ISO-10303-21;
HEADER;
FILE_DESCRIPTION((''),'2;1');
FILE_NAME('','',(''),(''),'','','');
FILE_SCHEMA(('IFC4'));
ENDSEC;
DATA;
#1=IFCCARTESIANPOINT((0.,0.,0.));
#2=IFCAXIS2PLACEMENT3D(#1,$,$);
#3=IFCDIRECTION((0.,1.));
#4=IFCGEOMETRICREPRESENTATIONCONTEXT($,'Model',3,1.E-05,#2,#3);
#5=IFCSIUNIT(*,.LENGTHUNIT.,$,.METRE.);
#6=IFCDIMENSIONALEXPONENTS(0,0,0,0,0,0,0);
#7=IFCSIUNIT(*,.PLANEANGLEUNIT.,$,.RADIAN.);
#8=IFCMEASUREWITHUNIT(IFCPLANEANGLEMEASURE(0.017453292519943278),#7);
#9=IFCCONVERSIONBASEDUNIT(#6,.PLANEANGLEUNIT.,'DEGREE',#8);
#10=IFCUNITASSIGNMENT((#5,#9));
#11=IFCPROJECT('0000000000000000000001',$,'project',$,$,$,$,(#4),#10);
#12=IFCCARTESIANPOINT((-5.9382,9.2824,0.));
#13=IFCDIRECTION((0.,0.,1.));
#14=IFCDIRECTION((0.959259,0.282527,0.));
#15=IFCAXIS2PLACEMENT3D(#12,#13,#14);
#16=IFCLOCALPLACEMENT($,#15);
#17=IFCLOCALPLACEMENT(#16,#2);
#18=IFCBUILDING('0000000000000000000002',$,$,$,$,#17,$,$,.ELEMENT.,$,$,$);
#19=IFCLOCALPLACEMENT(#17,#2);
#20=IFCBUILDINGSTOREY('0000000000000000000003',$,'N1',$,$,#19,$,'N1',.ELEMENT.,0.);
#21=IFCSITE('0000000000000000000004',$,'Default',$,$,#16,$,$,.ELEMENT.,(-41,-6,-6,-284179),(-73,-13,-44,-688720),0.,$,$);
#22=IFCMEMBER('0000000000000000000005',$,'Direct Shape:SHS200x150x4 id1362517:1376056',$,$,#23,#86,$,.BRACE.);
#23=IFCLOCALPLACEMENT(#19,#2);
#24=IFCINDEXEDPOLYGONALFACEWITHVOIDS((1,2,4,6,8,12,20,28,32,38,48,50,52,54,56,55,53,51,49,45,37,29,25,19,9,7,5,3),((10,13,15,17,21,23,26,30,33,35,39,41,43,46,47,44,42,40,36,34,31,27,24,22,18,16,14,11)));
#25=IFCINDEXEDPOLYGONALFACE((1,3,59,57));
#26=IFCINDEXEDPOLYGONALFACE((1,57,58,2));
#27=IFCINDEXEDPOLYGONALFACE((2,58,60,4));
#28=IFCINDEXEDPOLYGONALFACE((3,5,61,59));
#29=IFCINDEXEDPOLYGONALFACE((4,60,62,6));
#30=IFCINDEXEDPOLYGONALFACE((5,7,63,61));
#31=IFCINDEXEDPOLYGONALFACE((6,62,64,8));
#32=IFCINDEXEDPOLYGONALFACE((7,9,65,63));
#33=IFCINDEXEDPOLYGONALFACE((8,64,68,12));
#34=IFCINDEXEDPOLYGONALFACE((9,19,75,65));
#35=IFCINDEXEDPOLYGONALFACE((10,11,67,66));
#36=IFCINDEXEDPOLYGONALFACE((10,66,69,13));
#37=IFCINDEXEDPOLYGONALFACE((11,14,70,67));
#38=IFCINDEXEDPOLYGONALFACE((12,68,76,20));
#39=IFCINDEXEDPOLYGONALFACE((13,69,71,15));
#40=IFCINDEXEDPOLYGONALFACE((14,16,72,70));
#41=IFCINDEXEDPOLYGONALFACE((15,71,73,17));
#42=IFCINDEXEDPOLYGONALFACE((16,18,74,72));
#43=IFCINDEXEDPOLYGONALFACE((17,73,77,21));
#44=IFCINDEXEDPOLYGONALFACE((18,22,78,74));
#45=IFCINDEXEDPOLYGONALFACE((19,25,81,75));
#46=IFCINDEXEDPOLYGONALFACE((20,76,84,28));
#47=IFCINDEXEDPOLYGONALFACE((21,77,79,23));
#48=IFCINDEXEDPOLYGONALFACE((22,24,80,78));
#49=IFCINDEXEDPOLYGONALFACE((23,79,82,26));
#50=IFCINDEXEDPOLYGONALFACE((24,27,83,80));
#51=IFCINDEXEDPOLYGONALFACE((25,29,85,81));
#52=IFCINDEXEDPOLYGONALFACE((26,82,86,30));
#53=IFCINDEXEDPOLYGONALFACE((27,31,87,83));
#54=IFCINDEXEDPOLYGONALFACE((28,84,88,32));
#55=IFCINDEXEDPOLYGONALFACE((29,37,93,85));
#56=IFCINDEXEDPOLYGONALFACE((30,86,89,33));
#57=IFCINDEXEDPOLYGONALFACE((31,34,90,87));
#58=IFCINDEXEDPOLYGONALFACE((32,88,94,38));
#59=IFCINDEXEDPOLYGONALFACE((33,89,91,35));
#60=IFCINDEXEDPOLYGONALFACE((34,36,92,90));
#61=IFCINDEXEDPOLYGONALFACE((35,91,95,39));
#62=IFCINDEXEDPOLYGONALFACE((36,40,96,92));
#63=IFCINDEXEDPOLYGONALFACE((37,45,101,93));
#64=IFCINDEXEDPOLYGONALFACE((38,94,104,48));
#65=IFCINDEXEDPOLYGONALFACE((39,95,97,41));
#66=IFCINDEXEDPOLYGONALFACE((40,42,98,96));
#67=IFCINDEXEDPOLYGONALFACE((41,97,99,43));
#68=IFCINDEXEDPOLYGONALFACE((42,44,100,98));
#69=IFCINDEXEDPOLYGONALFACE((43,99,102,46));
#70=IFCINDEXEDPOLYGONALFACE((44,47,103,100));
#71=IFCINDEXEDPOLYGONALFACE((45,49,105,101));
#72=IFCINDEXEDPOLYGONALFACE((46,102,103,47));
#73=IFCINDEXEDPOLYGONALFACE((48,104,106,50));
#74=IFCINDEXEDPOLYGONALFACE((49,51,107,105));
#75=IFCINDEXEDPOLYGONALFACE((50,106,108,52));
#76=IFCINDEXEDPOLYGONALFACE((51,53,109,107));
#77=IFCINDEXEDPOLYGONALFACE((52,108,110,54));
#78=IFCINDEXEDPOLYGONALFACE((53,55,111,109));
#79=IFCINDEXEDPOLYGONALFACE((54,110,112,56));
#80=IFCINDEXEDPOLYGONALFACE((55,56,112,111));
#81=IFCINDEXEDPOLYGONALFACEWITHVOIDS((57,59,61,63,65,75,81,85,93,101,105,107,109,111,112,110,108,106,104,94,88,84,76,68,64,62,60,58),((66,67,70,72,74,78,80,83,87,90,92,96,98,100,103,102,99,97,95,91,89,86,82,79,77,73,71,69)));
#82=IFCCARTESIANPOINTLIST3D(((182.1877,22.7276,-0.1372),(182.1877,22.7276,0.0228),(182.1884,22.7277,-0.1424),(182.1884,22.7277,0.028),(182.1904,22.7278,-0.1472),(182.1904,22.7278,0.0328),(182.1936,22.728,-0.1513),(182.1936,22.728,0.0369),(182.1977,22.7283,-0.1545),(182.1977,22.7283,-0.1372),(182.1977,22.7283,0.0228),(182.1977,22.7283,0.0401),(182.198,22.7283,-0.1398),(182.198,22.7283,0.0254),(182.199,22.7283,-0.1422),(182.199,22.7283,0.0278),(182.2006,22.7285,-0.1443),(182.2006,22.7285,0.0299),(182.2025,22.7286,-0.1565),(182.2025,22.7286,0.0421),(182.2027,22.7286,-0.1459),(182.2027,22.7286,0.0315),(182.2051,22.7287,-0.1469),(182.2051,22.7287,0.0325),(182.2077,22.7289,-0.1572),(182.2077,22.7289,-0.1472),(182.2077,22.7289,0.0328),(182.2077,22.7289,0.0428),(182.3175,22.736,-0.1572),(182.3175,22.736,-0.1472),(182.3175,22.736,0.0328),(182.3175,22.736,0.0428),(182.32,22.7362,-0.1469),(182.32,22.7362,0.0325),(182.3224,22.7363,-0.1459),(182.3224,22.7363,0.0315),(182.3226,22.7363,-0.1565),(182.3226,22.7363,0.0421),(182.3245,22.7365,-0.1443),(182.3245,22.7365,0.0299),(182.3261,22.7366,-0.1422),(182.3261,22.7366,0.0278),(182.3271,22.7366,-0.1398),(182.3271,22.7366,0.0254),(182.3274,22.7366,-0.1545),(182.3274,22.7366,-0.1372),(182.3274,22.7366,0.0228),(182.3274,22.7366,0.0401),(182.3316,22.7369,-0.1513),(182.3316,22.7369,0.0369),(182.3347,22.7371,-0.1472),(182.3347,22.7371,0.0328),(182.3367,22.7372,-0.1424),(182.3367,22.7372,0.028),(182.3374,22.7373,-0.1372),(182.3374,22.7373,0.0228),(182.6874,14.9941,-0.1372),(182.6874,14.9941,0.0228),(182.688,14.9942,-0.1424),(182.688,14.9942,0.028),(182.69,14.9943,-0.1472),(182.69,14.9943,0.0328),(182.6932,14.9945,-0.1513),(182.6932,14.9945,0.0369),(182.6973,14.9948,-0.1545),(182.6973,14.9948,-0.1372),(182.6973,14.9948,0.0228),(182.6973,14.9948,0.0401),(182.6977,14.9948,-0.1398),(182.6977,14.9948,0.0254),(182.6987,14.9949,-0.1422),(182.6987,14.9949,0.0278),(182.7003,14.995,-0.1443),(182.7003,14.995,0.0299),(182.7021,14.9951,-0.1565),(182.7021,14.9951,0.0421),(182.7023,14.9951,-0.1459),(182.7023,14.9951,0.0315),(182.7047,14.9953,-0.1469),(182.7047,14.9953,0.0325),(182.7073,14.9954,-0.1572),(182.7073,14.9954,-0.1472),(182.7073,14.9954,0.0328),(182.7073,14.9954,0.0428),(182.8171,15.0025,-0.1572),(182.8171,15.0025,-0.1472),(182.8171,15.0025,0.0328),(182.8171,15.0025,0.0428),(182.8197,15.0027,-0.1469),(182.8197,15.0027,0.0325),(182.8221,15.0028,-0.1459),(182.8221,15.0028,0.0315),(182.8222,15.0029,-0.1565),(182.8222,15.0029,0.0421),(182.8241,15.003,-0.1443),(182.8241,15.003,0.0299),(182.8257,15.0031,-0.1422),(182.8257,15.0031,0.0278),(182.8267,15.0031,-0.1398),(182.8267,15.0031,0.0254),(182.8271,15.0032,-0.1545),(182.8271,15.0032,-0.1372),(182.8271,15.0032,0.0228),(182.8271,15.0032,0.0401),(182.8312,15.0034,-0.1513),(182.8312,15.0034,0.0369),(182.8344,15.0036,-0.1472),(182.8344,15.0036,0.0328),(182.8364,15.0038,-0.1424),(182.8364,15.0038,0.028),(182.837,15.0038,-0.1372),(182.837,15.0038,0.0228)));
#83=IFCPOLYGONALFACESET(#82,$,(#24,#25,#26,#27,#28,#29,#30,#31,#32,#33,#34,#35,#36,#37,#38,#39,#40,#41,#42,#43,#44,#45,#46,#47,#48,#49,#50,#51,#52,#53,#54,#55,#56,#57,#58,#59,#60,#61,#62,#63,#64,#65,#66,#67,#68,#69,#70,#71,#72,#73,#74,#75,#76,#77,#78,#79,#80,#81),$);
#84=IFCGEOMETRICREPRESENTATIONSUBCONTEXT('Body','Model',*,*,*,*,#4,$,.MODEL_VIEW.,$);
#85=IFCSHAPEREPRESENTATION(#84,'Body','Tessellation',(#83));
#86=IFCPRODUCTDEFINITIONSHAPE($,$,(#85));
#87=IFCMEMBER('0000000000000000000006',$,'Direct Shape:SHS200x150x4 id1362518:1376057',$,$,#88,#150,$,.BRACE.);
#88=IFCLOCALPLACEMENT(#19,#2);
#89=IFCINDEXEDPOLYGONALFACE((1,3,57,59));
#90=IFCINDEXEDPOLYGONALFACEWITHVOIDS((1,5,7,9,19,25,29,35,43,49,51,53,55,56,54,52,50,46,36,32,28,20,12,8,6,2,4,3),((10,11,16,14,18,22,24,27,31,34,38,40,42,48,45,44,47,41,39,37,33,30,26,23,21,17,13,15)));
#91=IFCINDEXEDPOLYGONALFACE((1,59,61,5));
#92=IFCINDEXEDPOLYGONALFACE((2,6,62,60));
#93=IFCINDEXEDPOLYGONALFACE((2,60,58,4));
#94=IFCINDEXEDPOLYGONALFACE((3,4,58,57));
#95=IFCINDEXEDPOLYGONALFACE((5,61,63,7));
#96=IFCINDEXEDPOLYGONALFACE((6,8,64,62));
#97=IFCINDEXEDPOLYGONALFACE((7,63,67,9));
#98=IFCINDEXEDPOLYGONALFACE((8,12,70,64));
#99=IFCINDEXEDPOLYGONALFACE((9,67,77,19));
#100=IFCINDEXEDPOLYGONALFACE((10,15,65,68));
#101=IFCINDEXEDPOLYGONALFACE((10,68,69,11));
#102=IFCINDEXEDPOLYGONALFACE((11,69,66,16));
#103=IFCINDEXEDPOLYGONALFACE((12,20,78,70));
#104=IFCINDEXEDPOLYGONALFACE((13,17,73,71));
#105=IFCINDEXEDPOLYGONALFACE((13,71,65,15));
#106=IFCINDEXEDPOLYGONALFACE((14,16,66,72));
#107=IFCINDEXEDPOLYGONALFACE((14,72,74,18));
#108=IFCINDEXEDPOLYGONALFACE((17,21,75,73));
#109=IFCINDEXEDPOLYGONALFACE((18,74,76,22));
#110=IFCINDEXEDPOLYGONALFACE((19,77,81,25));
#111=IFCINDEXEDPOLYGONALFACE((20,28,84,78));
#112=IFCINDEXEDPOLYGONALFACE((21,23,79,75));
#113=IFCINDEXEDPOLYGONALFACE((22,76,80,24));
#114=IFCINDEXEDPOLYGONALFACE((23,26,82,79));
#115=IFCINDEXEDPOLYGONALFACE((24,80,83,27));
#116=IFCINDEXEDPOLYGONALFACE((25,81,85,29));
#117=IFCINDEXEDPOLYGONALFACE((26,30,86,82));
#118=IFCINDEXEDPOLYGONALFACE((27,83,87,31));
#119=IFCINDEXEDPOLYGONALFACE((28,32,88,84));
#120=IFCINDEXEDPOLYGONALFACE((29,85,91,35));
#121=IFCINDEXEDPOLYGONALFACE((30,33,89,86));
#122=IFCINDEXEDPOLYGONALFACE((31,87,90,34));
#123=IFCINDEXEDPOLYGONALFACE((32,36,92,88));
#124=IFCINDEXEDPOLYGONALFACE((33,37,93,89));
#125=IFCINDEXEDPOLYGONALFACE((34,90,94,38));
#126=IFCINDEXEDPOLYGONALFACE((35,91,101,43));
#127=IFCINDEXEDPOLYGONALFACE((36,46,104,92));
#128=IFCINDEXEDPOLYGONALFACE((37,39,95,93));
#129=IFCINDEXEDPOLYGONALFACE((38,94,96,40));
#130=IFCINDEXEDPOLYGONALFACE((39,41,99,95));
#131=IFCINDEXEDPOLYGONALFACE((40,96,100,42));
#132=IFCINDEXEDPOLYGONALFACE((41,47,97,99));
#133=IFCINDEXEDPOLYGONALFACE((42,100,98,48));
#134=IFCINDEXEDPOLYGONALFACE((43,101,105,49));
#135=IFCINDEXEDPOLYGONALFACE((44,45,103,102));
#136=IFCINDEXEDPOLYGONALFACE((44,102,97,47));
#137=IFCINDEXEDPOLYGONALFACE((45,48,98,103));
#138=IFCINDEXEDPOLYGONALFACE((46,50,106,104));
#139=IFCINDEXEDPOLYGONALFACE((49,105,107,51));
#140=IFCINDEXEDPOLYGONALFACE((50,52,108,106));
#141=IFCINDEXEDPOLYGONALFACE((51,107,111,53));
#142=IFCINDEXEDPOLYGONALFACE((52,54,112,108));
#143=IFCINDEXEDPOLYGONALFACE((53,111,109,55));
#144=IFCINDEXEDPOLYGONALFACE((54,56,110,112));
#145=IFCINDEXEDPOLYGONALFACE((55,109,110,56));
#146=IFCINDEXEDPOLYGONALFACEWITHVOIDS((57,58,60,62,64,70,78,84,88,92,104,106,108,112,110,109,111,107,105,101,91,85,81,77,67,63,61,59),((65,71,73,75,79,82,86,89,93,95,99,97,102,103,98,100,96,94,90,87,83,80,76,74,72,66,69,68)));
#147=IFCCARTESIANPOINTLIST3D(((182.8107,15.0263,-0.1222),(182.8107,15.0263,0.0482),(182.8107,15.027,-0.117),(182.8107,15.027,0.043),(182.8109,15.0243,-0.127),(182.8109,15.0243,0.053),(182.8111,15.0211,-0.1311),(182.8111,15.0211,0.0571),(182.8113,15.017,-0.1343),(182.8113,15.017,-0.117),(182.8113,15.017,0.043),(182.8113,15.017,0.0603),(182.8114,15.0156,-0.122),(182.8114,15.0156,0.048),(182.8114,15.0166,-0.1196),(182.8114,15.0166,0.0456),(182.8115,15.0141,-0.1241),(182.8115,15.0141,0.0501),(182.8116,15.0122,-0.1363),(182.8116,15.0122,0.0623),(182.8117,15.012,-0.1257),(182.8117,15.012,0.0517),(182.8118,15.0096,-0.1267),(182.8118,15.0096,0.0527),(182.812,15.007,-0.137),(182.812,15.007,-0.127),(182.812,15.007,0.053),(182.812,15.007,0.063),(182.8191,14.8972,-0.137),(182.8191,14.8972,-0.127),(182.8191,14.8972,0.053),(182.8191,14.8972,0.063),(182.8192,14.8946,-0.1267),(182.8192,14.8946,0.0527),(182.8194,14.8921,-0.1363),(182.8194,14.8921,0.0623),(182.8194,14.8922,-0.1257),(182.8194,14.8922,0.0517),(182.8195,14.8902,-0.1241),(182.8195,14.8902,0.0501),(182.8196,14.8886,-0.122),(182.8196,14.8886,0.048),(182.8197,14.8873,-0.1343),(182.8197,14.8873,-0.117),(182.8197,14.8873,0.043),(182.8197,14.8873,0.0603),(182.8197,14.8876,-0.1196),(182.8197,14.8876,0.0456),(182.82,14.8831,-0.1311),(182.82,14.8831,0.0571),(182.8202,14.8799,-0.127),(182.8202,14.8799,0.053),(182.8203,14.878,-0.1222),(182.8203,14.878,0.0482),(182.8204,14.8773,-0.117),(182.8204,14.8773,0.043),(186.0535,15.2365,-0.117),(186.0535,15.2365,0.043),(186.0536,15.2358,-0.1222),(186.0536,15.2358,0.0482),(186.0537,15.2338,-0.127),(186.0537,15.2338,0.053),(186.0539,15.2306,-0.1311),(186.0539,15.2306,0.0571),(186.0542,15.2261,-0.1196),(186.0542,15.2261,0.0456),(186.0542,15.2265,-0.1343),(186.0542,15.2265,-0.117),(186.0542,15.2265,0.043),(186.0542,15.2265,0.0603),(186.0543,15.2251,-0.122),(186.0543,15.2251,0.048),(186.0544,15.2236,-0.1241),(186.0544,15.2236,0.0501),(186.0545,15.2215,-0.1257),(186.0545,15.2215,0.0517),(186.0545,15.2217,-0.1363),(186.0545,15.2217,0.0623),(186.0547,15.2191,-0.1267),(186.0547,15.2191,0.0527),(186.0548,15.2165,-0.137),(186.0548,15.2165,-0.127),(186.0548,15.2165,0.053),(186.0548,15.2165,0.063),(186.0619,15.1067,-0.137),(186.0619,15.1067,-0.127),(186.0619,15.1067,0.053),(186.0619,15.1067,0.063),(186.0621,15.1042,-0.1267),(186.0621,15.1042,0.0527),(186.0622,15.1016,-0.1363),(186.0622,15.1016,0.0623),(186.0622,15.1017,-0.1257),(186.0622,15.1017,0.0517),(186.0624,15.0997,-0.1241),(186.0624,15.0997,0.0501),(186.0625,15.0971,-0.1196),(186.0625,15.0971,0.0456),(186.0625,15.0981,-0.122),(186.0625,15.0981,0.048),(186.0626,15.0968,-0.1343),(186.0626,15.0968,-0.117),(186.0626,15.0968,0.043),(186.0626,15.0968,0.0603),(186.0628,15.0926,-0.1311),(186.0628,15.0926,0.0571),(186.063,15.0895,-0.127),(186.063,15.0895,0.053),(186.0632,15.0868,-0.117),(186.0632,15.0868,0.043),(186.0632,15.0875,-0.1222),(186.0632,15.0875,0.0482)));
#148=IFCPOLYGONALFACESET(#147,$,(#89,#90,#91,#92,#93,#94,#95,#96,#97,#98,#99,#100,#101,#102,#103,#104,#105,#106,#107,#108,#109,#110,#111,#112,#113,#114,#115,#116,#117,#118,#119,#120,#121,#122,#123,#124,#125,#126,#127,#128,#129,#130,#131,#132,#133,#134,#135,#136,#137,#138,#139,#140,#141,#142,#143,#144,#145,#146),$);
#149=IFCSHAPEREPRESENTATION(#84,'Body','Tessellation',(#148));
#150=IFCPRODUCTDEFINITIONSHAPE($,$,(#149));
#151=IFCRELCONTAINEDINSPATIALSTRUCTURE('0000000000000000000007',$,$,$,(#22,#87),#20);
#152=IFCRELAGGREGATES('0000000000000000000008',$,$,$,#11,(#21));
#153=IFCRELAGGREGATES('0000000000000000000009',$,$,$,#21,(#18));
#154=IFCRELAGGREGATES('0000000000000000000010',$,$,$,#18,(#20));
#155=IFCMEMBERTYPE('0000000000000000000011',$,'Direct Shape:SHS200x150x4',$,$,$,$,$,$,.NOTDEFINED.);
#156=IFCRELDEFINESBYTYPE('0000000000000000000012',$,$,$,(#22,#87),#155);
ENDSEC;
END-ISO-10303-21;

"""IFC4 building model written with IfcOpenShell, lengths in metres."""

from ifc_helpers import new_model, entity, si_unit, converted_unit, direction, frame, frame_2d, origin, place, context, subcontext, project, spatial, polyline, circle_curve, parameter, trimmed, segment, composite_curve, outline, extrude, type_object, element, save


model = new_model("IFC4")

# Units and contexts
model_context = context("Model", 3, precision=1e-05, world=origin(), true_north=direction((0.0, 1.0)))
body_context = subcontext(model_context, "Body", "Model", "MODEL_VIEW")
ifc_project = project(units=[si_unit("LENGTHUNIT", "METRE"), converted_unit("PLANEANGLEUNIT", "DEGREE", entity("IfcPlaneAngleMeasure", 0.017453292519943278), si_unit("PLANEANGLEUNIT", "RADIAN"), dimensions=[0, 0, 0, 0, 0, 0, 0])], contexts=[model_context])

# Site, building, storey
site_placement = place(None, frame((-5.9382, 9.2824, 0.0), z_axis=(0.0, 0.0, 1.0), x_axis=(0.959259, 0.282527, 0.0)))
site = spatial("IfcSite", under=ifc_project, at=site_placement, Name="Default", CompositionType="ELEMENT", RefLatitude=(-41, -6, -6, -284179), RefLongitude=(-73, -13, -44, -688720), RefElevation=0.0)
building_placement = place(site_placement, origin())
building = spatial("IfcBuilding", under=site, at=building_placement, CompositionType="ELEMENT")
storey_placement = place(building_placement, origin())
storey = spatial("IfcBuildingStorey", under=building, at=storey_placement, Name="N1", LongName="N1", CompositionType="ELEMENT", Elevation=0.0)

# Members
member_type_1 = type_object("IfcMemberType", Name="Direct Shape:SHS200x150x4", PredefinedType="NOTDEFINED")
member_1_placement = place(storey_placement, origin())
element("IfcMember", 1, at=member_1_placement, inside=storey, type_object=member_type_1, Name="Direct Shape:SHS200x150x4 id1362517:1376056", PredefinedType="BRACE", context=body_context, shape_type="SweptSolid", body=[
    extrude(outline(composite_curve([segment(polyline([(-0.08, -0.075), (0.08, -0.075)]), True, "CONTINUOUS"), segment(trimmed(circle_curve(frame_2d((0.08, -0.055), x_axis=(0.0, 1.0)), 0.02), [parameter(180.0)], [parameter(270.0)], True, "PARAMETER"), True, "CONTINUOUS"), segment(polyline([(0.1, -0.055), (0.1, 0.055)]), True, "CONTINUOUS"), segment(trimmed(circle_curve(frame_2d((0.08, 0.055), x_axis=(0.0, 1.0)), 0.02), [parameter(270.0)], [parameter(0.0)], True, "PARAMETER"), True, "CONTINUOUS"), segment(polyline([(0.08, 0.075), (-0.08, 0.075)]), True, "CONTINUOUS"), segment(trimmed(circle_curve(frame_2d((-0.08, 0.055), x_axis=(0.0, 1.0)), 0.02), [parameter(360.0)], [parameter(90.0)], True, "PARAMETER"), True, "CONTINUOUS"), segment(polyline([(-0.1, 0.055), (-0.1, -0.055)]), True, "CONTINUOUS"), segment(trimmed(circle_curve(frame_2d((-0.08, -0.055), x_axis=(0.0, 1.0)), 0.02), [parameter(90.0)], [parameter(180.0)], True, "PARAMETER"), True, "CONTINUOUS")], self_intersect=False), holes=[composite_curve([segment(trimmed(circle_curve(frame_2d((-0.08, 0.055), x_axis=(0.0, 1.0)), 0.01), [parameter(360.0)], [parameter(90.0)], True, "PARAMETER"), False, "CONTINUOUS"), segment(polyline([(-0.08, 0.065), (0.08, 0.065)]), True, "CONTINUOUS"), segment(trimmed(circle_curve(frame_2d((0.08, 0.055), x_axis=(0.0, 1.0)), 0.01), [parameter(270.0)], [parameter(0.0)], True, "PARAMETER"), False, "CONTINUOUS"), segment(polyline([(0.09, 0.055), (0.09, -0.055)]), True, "CONTINUOUS"), segment(trimmed(circle_curve(frame_2d((0.08, -0.055), x_axis=(0.0, 1.0)), 0.01), [parameter(180.0)], [parameter(270.0)], True, "PARAMETER"), False, "CONTINUOUS"), segment(polyline([(0.08, -0.065), (-0.08, -0.065)]), True, "CONTINUOUS"), segment(trimmed(circle_curve(frame_2d((-0.08, -0.055), x_axis=(0.0, 1.0)), 0.01), [parameter(90.0)], [parameter(180.0)], True, "PARAMETER"), False, "CONTINUOUS"), segment(polyline([(-0.09, -0.055), (-0.09, 0.055)]), True, "CONTINUOUS")], self_intersect=False)]), frame((182.7622, 14.999, -0.0572), z_axis=(-0.064471, 0.99792, 0.0), x_axis=(0.0, 0.0, -1.0)), (0.0, 0.0, 1.0), 7.7496),
])
member_2_placement = place(storey_placement, origin())
element("IfcMember", 2, at=member_2_placement, inside=storey, type_object=member_type_1, Name="Direct Shape:SHS200x150x4 id1362518:1376057", PredefinedType="BRACE", context=body_context, shape_type="SweptSolid", body=[
    extrude(outline(composite_curve([segment(polyline([(-0.08, -0.075), (0.08, -0.075)]), True, "CONTINUOUS"), segment(trimmed(circle_curve(frame_2d((0.08, -0.055), x_axis=(0.0, 1.0)), 0.02), [parameter(180.0)], [parameter(270.0)], True, "PARAMETER"), True, "CONTINUOUS"), segment(polyline([(0.1, -0.055), (0.1, 0.055)]), True, "CONTINUOUS"), segment(trimmed(circle_curve(frame_2d((0.08, 0.055), x_axis=(0.0, 1.0)), 0.02), [parameter(270.0)], [parameter(0.0)], True, "PARAMETER"), True, "CONTINUOUS"), segment(polyline([(0.08, 0.075), (-0.08, 0.075)]), True, "CONTINUOUS"), segment(trimmed(circle_curve(frame_2d((-0.08, 0.055), x_axis=(0.0, 1.0)), 0.02), [parameter(360.0)], [parameter(90.0)], True, "PARAMETER"), True, "CONTINUOUS"), segment(polyline([(-0.1, 0.055), (-0.1, -0.055)]), True, "CONTINUOUS"), segment(trimmed(circle_curve(frame_2d((-0.08, -0.055), x_axis=(0.0, 1.0)), 0.02), [parameter(90.0)], [parameter(180.0)], True, "PARAMETER"), True, "CONTINUOUS")], self_intersect=False), holes=[composite_curve([segment(trimmed(circle_curve(frame_2d((-0.08, 0.055), x_axis=(0.0, 1.0)), 0.01), [parameter(360.0)], [parameter(90.0)], True, "PARAMETER"), False, "CONTINUOUS"), segment(polyline([(-0.08, 0.065), (0.08, 0.065)]), True, "CONTINUOUS"), segment(trimmed(circle_curve(frame_2d((0.08, 0.055), x_axis=(0.0, 1.0)), 0.01), [parameter(270.0)], [parameter(0.0)], True, "PARAMETER"), False, "CONTINUOUS"), segment(polyline([(0.09, 0.055), (0.09, -0.055)]), True, "CONTINUOUS"), segment(trimmed(circle_curve(frame_2d((0.08, -0.055), x_axis=(0.0, 1.0)), 0.01), [parameter(180.0)], [parameter(270.0)], True, "PARAMETER"), False, "CONTINUOUS"), segment(polyline([(0.08, -0.065), (-0.08, -0.065)]), True, "CONTINUOUS"), segment(trimmed(circle_curve(frame_2d((-0.08, -0.055), x_axis=(0.0, 1.0)), 0.01), [parameter(90.0)], [parameter(180.0)], True, "PARAMETER"), False, "CONTINUOUS"), segment(polyline([(-0.09, -0.055), (-0.09, 0.055)]), True, "CONTINUOUS")], self_intersect=False)]), frame((182.8155, 14.9521, -0.037), z_axis=(0.99792, 0.064471, 0.0), x_axis=(0.0, 0.0, -1.0)), (0.0, 0.0, 1.0), 3.2496),
])

save(model, "model.ifc")
